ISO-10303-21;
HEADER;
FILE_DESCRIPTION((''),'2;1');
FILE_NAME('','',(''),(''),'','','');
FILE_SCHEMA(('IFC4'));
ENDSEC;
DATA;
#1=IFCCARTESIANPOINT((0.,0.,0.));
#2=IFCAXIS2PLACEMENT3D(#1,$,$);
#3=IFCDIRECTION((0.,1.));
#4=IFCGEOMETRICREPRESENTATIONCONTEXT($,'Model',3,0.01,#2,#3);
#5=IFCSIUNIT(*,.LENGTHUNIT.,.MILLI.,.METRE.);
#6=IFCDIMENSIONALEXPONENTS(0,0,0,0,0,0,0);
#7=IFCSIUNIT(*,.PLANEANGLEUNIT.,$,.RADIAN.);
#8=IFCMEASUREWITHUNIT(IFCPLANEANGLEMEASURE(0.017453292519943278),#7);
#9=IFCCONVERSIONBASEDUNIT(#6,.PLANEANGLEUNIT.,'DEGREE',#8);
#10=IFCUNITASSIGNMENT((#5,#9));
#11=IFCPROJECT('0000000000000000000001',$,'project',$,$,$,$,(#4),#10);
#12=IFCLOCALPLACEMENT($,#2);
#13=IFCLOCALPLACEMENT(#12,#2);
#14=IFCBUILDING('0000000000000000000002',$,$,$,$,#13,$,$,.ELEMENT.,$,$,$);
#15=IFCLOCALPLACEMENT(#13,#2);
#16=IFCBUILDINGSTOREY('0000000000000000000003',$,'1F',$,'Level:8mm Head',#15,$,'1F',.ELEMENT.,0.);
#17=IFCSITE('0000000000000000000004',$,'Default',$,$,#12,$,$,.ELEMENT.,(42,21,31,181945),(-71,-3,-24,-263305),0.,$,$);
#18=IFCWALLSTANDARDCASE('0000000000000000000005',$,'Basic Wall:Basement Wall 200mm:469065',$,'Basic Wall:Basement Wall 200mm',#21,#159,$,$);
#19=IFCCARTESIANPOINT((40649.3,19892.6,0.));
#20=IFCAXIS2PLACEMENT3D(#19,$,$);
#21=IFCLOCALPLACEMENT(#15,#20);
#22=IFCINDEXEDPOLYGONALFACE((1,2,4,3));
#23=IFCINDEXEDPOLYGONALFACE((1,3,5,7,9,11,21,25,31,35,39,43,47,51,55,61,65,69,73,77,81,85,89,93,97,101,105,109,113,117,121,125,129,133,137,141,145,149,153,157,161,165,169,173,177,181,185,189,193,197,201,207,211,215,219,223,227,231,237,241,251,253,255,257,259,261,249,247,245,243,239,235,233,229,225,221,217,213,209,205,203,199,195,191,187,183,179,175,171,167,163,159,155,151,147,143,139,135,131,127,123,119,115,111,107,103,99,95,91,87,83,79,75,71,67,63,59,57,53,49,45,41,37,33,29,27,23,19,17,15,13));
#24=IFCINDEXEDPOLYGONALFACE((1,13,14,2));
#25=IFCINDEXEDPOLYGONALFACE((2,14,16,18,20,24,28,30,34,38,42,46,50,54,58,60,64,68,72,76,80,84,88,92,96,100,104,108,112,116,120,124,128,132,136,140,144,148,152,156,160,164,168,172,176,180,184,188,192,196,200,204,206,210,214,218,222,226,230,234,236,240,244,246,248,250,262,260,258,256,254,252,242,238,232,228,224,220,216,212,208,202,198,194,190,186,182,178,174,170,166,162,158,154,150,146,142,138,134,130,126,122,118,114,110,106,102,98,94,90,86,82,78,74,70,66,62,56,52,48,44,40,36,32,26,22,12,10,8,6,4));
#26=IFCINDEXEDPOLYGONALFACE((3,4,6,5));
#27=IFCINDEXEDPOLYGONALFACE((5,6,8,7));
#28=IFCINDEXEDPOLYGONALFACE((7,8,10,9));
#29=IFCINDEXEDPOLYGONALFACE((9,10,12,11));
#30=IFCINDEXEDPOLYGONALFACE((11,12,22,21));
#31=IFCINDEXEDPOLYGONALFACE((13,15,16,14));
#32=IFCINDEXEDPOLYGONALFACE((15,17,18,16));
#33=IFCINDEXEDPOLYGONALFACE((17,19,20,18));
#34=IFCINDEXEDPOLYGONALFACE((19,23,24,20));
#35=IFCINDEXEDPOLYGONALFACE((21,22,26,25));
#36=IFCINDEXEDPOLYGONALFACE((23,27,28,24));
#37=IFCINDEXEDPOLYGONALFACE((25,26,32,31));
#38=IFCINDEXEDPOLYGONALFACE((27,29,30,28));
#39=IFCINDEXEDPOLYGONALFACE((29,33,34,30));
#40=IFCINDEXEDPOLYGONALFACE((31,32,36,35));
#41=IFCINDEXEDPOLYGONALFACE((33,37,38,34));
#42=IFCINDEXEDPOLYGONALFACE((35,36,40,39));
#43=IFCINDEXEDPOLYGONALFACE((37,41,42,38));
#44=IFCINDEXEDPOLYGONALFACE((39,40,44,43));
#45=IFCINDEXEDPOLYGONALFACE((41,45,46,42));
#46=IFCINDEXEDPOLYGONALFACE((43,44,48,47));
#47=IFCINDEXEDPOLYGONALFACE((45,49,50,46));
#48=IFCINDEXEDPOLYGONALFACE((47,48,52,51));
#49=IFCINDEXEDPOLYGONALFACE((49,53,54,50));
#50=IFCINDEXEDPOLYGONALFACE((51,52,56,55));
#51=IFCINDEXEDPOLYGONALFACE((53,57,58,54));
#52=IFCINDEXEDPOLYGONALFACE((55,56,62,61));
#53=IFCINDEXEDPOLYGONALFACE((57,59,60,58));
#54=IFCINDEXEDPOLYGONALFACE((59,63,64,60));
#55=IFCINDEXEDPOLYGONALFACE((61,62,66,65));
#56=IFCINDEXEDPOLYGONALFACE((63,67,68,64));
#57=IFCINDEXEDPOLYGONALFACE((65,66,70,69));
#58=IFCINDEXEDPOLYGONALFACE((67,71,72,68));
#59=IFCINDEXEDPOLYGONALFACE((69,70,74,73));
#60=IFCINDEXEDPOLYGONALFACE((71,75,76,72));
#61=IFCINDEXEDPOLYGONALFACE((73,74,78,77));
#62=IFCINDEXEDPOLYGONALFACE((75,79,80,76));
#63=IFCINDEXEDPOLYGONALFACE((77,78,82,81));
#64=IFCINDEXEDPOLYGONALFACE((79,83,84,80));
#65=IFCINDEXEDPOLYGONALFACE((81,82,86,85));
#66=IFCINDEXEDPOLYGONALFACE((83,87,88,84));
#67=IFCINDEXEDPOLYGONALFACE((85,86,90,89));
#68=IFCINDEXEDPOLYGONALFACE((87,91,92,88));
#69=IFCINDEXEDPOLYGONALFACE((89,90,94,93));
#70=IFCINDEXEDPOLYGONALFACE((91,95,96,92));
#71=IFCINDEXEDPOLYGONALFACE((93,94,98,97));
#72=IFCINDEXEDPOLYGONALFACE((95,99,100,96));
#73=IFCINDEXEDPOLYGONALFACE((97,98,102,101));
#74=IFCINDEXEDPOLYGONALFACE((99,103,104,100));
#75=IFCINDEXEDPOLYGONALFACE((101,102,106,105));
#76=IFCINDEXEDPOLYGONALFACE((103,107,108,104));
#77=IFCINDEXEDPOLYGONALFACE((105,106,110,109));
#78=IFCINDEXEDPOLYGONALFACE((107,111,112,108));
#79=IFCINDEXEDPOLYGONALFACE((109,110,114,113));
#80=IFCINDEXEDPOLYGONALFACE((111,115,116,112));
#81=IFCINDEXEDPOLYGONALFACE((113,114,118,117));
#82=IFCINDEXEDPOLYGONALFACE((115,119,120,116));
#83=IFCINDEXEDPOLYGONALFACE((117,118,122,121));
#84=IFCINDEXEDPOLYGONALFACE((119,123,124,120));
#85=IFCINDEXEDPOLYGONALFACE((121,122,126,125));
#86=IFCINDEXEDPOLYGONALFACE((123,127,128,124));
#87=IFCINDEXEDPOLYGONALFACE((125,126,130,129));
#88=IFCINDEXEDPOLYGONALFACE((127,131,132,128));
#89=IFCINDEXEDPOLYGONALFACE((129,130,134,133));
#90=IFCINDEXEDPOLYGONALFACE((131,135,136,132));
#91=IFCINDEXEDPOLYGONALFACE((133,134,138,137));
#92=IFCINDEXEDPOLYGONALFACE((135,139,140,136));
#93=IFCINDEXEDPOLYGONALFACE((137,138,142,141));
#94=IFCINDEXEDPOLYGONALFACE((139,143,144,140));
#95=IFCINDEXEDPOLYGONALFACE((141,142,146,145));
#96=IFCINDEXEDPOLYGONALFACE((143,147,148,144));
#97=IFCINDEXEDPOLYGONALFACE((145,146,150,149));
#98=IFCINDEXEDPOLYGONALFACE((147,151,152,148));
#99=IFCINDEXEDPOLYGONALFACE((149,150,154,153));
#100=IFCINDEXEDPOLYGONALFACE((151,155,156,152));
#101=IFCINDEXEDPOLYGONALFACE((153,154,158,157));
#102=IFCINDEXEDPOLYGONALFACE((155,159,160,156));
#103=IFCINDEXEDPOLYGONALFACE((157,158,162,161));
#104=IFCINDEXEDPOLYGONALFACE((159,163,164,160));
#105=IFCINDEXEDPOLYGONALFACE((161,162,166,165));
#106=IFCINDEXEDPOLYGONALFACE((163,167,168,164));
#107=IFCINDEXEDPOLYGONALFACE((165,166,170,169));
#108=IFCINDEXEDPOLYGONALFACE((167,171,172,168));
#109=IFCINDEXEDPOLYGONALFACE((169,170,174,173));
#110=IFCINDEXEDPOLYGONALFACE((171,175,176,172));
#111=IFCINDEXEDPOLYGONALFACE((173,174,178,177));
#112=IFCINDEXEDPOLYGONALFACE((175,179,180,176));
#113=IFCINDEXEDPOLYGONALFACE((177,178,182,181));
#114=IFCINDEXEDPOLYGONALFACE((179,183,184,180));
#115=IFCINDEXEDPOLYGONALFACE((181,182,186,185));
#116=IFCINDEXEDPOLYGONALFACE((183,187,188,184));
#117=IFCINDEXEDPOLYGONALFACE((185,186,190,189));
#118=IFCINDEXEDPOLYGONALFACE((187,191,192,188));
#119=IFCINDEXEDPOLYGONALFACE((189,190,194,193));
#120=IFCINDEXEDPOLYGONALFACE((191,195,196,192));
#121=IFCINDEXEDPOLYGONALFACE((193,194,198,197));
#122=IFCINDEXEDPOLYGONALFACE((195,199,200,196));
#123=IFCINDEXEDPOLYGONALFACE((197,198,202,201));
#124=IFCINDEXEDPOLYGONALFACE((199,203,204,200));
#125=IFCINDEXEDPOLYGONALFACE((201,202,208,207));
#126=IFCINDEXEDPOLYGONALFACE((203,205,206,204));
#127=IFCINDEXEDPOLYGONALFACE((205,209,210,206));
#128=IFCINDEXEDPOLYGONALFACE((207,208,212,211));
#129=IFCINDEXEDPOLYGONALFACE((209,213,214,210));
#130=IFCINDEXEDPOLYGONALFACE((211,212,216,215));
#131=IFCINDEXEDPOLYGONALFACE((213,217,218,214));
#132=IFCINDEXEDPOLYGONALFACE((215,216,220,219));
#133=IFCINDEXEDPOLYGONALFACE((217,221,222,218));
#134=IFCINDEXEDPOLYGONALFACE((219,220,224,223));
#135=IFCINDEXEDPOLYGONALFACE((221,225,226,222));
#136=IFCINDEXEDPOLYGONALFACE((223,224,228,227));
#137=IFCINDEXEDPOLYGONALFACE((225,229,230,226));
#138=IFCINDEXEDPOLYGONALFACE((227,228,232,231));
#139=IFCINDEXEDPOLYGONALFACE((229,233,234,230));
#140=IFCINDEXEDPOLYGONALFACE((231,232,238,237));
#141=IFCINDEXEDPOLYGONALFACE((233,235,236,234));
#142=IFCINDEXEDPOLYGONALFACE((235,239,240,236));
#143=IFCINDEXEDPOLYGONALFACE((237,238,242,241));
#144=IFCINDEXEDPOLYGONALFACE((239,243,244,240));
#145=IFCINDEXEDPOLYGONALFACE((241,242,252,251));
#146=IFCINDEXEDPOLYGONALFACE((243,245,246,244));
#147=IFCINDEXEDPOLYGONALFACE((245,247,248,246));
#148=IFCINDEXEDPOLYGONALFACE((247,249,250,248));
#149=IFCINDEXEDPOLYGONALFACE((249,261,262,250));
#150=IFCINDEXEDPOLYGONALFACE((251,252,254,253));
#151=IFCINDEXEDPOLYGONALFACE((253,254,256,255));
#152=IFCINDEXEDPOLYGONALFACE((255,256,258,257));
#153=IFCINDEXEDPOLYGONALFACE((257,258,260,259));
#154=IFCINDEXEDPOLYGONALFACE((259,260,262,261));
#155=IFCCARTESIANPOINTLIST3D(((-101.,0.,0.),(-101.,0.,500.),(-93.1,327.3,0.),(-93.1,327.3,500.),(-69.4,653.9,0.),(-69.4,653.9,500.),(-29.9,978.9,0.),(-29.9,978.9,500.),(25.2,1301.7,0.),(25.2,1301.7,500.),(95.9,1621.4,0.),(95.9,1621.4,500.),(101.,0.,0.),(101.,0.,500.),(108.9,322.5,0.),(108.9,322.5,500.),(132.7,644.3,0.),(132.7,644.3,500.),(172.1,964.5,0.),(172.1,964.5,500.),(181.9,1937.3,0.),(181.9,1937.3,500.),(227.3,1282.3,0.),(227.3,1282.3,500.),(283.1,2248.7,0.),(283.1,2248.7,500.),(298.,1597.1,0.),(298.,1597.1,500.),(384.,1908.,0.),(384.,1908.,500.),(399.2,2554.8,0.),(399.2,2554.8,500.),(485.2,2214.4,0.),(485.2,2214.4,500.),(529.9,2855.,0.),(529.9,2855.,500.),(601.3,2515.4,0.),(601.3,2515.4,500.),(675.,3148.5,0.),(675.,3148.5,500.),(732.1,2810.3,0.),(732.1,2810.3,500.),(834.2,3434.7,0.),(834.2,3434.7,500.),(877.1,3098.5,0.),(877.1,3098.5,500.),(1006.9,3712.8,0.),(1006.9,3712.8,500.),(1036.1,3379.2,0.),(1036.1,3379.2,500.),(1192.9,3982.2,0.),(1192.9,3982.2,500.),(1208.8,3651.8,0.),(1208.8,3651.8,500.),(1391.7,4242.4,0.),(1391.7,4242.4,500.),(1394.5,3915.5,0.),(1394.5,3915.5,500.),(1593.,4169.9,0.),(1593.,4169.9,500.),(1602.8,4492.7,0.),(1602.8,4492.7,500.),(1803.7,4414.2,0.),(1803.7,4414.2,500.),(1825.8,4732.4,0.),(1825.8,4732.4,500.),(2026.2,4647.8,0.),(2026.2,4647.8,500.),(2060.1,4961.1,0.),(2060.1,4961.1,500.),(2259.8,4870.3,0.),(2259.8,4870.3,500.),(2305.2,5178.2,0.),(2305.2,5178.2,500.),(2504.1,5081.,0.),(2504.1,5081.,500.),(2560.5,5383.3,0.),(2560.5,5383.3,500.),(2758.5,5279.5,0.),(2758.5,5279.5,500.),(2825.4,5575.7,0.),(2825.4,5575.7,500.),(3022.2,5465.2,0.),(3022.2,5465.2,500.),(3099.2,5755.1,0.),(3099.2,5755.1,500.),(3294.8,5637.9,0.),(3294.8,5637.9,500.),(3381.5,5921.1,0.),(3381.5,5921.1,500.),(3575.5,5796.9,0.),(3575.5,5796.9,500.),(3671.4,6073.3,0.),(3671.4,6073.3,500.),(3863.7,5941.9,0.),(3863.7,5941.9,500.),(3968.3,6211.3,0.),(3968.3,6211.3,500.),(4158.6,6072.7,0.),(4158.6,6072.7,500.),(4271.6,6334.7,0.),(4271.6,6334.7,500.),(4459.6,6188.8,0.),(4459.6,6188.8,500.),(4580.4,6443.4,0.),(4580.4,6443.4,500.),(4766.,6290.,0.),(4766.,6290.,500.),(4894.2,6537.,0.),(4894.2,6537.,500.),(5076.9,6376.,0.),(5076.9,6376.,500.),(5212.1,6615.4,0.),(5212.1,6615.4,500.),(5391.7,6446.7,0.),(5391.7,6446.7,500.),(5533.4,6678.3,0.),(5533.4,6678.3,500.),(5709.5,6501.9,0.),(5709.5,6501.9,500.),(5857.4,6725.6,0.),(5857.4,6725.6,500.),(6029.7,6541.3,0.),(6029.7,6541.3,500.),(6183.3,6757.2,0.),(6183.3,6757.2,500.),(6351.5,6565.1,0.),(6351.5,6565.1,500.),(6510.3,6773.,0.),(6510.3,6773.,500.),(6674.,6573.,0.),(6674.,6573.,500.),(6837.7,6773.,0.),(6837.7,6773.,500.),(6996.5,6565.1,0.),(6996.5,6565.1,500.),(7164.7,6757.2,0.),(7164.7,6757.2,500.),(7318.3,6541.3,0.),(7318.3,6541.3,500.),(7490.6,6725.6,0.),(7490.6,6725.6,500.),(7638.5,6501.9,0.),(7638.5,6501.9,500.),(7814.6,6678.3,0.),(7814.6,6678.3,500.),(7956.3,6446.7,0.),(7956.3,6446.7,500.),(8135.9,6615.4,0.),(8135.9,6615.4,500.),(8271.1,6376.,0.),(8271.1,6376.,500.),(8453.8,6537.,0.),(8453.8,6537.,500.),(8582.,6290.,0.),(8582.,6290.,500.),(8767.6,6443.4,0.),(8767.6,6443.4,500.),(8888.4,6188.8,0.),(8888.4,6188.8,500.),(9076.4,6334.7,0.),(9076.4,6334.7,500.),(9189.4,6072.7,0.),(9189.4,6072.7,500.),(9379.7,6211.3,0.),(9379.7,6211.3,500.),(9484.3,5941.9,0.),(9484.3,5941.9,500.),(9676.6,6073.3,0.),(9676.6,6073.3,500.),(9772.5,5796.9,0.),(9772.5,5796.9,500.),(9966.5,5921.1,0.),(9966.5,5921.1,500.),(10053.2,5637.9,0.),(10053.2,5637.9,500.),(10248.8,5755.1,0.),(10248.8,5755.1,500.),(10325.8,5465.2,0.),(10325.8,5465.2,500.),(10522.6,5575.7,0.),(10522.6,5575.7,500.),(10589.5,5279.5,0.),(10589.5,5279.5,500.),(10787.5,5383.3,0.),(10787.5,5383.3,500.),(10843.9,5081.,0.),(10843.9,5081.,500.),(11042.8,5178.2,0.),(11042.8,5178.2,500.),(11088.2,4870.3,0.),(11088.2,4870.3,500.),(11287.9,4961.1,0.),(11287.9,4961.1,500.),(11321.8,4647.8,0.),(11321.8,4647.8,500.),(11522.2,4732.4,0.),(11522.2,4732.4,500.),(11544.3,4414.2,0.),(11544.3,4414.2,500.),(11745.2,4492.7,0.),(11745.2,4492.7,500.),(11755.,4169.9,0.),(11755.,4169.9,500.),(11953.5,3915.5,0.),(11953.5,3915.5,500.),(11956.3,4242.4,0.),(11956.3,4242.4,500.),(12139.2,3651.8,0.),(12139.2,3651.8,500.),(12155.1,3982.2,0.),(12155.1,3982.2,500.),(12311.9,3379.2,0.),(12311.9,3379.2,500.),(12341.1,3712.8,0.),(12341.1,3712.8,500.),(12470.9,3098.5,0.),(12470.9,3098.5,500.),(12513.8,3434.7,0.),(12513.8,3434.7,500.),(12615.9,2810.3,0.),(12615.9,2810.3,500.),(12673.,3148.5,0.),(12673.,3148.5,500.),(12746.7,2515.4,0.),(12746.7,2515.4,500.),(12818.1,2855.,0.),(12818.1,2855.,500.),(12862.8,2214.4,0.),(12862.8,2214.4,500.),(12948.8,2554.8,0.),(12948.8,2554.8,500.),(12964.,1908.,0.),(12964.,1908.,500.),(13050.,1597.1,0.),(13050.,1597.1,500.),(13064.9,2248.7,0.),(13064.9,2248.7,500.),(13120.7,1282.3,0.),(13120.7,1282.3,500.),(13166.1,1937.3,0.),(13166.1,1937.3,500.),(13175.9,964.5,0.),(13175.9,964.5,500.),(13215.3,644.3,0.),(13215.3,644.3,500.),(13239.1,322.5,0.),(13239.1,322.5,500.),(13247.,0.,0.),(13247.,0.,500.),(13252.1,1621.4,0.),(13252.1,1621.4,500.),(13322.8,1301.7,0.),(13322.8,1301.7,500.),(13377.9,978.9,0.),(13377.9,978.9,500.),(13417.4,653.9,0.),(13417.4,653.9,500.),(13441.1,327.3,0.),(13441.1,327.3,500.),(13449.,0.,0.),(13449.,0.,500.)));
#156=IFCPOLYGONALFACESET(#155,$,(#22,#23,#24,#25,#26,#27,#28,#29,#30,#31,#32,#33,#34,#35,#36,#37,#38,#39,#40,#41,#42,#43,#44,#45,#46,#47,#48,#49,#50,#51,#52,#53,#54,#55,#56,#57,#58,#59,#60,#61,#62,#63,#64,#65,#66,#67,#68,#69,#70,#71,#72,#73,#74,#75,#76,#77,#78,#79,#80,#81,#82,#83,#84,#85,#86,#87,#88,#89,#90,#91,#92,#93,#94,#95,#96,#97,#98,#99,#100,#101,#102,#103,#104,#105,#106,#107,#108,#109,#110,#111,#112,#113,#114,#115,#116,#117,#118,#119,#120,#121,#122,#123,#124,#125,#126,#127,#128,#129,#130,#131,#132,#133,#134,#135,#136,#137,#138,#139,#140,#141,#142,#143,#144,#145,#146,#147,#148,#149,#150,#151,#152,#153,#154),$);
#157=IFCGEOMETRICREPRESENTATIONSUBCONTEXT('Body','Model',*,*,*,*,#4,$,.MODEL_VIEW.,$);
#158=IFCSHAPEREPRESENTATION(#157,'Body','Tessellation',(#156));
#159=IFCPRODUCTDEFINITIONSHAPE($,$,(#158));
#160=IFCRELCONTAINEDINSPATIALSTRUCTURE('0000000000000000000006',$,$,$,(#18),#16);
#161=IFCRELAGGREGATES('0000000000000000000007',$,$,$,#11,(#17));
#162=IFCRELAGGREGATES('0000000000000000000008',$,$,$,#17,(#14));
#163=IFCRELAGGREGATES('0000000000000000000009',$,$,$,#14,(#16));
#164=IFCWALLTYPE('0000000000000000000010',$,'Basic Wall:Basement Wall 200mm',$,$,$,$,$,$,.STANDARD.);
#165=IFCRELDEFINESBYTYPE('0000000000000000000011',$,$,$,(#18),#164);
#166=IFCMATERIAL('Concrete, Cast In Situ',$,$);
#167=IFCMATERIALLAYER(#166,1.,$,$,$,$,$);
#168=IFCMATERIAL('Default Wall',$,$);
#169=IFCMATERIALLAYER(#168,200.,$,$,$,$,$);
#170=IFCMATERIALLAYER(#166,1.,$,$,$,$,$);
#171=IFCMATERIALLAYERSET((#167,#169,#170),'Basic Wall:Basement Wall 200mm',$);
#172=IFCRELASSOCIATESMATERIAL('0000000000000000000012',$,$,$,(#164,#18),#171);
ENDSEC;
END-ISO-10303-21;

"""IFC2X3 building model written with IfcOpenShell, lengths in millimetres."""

from ifc_helpers import new_model, entity, si_unit, converted_unit, direction, frame, frame_2d, origin, place, context, subcontext, project, spatial, polyline, circle_curve, parameter, trimmed, segment, composite_curve, outline, extrude, material, layer, layer_set, layer_usage, type_object, element, save


model = new_model("IFC2X3")

# Units and contexts
model_context = context("Model", 3, precision=0.01, world=origin(), true_north=direction((0.0, 1.0)))
body_context = subcontext(model_context, "Body", "Model", "MODEL_VIEW")
ifc_project = project(units=[si_unit("LENGTHUNIT", "METRE", prefix="MILLI"), converted_unit("PLANEANGLEUNIT", "DEGREE", entity("IfcPlaneAngleMeasure", 0.017453292519943278), si_unit("PLANEANGLEUNIT", "RADIAN"), dimensions=[0, 0, 0, 0, 0, 0, 0])], contexts=[model_context])

# Site, building, storey
site_placement = place(None, origin())
site = spatial("IfcSite", under=ifc_project, at=site_placement, Name="Default", CompositionType="ELEMENT", RefLatitude=(42, 21, 31, 181945), RefLongitude=(-71, -3, -24, -263305), RefElevation=0.0)
building_placement = place(site_placement, origin())
building = spatial("IfcBuilding", under=site, at=building_placement, CompositionType="ELEMENT")
storey_placement = place(building_placement, origin())
storey = spatial("IfcBuildingStorey", under=building, at=storey_placement, Name="1F", ObjectType="Level:8mm Head", LongName="1F", CompositionType="ELEMENT", Elevation=0.0)

# Shared definitions
ifc_material_1 = material(Name="Default Wall")

# Wall
ifc_material_2 = material(Name="Concrete, Cast In Situ")
ifc_layer_1 = layer(ifc_material_2, 1.0)
ifc_layer_2 = layer(ifc_material_1, 200.0)
ifc_layer_3 = layer(ifc_material_2, 1.0)
ifc_layer_set_1 = layer_set([ifc_layer_1, ifc_layer_2, ifc_layer_3], Name="Basic Wall:Basement Wall 200mm")
wall_type_1 = type_object("IfcWallType", Name="Basic Wall:Basement Wall 200mm", PredefinedType="STANDARD", material=ifc_layer_set_1)
ifc_layer_usage_1 = layer_usage(ifc_layer_set_1, "AXIS2", "POSITIVE", -101.0)
wall_1_placement = place(storey_placement, frame((40649.3, 19892.6, 0.0)))
element("IfcWallStandardCase", 1, at=wall_1_placement, inside=storey, type_object=wall_type_1, material=ifc_layer_usage_1, Name="Basic Wall:Basement Wall 200mm:469065", ObjectType="Basic Wall:Basement Wall 200mm", context=body_context, shape_type="SweptSolid", body=[
    extrude(outline(composite_curve([segment(trimmed(circle_curve(frame_2d((6674.0, 0.0), x_axis=(1.0, 0.0)), 6775.0), [parameter(0.0)], [parameter(180.0)], True, "PARAMETER"), True, "CONTINUOUS"), segment(polyline([(-101.0, 0.0), (101.0, 0.0)]), True, "CONTINUOUS"), segment(trimmed(circle_curve(frame_2d((6674.0, 0.0), x_axis=(1.0, 0.0)), 6573.0), [parameter(0.0)], [parameter(180.0)], True, "PARAMETER"), False, "CONTINUOUS"), segment(polyline([(13247.0, 0.0), (13449.0, 0.0)]), True, "CONTINUOUS")], self_intersect=False)), origin(), (0.0, 0.0, 1.0), 500.0),
])

save(model, "model.ifc")
